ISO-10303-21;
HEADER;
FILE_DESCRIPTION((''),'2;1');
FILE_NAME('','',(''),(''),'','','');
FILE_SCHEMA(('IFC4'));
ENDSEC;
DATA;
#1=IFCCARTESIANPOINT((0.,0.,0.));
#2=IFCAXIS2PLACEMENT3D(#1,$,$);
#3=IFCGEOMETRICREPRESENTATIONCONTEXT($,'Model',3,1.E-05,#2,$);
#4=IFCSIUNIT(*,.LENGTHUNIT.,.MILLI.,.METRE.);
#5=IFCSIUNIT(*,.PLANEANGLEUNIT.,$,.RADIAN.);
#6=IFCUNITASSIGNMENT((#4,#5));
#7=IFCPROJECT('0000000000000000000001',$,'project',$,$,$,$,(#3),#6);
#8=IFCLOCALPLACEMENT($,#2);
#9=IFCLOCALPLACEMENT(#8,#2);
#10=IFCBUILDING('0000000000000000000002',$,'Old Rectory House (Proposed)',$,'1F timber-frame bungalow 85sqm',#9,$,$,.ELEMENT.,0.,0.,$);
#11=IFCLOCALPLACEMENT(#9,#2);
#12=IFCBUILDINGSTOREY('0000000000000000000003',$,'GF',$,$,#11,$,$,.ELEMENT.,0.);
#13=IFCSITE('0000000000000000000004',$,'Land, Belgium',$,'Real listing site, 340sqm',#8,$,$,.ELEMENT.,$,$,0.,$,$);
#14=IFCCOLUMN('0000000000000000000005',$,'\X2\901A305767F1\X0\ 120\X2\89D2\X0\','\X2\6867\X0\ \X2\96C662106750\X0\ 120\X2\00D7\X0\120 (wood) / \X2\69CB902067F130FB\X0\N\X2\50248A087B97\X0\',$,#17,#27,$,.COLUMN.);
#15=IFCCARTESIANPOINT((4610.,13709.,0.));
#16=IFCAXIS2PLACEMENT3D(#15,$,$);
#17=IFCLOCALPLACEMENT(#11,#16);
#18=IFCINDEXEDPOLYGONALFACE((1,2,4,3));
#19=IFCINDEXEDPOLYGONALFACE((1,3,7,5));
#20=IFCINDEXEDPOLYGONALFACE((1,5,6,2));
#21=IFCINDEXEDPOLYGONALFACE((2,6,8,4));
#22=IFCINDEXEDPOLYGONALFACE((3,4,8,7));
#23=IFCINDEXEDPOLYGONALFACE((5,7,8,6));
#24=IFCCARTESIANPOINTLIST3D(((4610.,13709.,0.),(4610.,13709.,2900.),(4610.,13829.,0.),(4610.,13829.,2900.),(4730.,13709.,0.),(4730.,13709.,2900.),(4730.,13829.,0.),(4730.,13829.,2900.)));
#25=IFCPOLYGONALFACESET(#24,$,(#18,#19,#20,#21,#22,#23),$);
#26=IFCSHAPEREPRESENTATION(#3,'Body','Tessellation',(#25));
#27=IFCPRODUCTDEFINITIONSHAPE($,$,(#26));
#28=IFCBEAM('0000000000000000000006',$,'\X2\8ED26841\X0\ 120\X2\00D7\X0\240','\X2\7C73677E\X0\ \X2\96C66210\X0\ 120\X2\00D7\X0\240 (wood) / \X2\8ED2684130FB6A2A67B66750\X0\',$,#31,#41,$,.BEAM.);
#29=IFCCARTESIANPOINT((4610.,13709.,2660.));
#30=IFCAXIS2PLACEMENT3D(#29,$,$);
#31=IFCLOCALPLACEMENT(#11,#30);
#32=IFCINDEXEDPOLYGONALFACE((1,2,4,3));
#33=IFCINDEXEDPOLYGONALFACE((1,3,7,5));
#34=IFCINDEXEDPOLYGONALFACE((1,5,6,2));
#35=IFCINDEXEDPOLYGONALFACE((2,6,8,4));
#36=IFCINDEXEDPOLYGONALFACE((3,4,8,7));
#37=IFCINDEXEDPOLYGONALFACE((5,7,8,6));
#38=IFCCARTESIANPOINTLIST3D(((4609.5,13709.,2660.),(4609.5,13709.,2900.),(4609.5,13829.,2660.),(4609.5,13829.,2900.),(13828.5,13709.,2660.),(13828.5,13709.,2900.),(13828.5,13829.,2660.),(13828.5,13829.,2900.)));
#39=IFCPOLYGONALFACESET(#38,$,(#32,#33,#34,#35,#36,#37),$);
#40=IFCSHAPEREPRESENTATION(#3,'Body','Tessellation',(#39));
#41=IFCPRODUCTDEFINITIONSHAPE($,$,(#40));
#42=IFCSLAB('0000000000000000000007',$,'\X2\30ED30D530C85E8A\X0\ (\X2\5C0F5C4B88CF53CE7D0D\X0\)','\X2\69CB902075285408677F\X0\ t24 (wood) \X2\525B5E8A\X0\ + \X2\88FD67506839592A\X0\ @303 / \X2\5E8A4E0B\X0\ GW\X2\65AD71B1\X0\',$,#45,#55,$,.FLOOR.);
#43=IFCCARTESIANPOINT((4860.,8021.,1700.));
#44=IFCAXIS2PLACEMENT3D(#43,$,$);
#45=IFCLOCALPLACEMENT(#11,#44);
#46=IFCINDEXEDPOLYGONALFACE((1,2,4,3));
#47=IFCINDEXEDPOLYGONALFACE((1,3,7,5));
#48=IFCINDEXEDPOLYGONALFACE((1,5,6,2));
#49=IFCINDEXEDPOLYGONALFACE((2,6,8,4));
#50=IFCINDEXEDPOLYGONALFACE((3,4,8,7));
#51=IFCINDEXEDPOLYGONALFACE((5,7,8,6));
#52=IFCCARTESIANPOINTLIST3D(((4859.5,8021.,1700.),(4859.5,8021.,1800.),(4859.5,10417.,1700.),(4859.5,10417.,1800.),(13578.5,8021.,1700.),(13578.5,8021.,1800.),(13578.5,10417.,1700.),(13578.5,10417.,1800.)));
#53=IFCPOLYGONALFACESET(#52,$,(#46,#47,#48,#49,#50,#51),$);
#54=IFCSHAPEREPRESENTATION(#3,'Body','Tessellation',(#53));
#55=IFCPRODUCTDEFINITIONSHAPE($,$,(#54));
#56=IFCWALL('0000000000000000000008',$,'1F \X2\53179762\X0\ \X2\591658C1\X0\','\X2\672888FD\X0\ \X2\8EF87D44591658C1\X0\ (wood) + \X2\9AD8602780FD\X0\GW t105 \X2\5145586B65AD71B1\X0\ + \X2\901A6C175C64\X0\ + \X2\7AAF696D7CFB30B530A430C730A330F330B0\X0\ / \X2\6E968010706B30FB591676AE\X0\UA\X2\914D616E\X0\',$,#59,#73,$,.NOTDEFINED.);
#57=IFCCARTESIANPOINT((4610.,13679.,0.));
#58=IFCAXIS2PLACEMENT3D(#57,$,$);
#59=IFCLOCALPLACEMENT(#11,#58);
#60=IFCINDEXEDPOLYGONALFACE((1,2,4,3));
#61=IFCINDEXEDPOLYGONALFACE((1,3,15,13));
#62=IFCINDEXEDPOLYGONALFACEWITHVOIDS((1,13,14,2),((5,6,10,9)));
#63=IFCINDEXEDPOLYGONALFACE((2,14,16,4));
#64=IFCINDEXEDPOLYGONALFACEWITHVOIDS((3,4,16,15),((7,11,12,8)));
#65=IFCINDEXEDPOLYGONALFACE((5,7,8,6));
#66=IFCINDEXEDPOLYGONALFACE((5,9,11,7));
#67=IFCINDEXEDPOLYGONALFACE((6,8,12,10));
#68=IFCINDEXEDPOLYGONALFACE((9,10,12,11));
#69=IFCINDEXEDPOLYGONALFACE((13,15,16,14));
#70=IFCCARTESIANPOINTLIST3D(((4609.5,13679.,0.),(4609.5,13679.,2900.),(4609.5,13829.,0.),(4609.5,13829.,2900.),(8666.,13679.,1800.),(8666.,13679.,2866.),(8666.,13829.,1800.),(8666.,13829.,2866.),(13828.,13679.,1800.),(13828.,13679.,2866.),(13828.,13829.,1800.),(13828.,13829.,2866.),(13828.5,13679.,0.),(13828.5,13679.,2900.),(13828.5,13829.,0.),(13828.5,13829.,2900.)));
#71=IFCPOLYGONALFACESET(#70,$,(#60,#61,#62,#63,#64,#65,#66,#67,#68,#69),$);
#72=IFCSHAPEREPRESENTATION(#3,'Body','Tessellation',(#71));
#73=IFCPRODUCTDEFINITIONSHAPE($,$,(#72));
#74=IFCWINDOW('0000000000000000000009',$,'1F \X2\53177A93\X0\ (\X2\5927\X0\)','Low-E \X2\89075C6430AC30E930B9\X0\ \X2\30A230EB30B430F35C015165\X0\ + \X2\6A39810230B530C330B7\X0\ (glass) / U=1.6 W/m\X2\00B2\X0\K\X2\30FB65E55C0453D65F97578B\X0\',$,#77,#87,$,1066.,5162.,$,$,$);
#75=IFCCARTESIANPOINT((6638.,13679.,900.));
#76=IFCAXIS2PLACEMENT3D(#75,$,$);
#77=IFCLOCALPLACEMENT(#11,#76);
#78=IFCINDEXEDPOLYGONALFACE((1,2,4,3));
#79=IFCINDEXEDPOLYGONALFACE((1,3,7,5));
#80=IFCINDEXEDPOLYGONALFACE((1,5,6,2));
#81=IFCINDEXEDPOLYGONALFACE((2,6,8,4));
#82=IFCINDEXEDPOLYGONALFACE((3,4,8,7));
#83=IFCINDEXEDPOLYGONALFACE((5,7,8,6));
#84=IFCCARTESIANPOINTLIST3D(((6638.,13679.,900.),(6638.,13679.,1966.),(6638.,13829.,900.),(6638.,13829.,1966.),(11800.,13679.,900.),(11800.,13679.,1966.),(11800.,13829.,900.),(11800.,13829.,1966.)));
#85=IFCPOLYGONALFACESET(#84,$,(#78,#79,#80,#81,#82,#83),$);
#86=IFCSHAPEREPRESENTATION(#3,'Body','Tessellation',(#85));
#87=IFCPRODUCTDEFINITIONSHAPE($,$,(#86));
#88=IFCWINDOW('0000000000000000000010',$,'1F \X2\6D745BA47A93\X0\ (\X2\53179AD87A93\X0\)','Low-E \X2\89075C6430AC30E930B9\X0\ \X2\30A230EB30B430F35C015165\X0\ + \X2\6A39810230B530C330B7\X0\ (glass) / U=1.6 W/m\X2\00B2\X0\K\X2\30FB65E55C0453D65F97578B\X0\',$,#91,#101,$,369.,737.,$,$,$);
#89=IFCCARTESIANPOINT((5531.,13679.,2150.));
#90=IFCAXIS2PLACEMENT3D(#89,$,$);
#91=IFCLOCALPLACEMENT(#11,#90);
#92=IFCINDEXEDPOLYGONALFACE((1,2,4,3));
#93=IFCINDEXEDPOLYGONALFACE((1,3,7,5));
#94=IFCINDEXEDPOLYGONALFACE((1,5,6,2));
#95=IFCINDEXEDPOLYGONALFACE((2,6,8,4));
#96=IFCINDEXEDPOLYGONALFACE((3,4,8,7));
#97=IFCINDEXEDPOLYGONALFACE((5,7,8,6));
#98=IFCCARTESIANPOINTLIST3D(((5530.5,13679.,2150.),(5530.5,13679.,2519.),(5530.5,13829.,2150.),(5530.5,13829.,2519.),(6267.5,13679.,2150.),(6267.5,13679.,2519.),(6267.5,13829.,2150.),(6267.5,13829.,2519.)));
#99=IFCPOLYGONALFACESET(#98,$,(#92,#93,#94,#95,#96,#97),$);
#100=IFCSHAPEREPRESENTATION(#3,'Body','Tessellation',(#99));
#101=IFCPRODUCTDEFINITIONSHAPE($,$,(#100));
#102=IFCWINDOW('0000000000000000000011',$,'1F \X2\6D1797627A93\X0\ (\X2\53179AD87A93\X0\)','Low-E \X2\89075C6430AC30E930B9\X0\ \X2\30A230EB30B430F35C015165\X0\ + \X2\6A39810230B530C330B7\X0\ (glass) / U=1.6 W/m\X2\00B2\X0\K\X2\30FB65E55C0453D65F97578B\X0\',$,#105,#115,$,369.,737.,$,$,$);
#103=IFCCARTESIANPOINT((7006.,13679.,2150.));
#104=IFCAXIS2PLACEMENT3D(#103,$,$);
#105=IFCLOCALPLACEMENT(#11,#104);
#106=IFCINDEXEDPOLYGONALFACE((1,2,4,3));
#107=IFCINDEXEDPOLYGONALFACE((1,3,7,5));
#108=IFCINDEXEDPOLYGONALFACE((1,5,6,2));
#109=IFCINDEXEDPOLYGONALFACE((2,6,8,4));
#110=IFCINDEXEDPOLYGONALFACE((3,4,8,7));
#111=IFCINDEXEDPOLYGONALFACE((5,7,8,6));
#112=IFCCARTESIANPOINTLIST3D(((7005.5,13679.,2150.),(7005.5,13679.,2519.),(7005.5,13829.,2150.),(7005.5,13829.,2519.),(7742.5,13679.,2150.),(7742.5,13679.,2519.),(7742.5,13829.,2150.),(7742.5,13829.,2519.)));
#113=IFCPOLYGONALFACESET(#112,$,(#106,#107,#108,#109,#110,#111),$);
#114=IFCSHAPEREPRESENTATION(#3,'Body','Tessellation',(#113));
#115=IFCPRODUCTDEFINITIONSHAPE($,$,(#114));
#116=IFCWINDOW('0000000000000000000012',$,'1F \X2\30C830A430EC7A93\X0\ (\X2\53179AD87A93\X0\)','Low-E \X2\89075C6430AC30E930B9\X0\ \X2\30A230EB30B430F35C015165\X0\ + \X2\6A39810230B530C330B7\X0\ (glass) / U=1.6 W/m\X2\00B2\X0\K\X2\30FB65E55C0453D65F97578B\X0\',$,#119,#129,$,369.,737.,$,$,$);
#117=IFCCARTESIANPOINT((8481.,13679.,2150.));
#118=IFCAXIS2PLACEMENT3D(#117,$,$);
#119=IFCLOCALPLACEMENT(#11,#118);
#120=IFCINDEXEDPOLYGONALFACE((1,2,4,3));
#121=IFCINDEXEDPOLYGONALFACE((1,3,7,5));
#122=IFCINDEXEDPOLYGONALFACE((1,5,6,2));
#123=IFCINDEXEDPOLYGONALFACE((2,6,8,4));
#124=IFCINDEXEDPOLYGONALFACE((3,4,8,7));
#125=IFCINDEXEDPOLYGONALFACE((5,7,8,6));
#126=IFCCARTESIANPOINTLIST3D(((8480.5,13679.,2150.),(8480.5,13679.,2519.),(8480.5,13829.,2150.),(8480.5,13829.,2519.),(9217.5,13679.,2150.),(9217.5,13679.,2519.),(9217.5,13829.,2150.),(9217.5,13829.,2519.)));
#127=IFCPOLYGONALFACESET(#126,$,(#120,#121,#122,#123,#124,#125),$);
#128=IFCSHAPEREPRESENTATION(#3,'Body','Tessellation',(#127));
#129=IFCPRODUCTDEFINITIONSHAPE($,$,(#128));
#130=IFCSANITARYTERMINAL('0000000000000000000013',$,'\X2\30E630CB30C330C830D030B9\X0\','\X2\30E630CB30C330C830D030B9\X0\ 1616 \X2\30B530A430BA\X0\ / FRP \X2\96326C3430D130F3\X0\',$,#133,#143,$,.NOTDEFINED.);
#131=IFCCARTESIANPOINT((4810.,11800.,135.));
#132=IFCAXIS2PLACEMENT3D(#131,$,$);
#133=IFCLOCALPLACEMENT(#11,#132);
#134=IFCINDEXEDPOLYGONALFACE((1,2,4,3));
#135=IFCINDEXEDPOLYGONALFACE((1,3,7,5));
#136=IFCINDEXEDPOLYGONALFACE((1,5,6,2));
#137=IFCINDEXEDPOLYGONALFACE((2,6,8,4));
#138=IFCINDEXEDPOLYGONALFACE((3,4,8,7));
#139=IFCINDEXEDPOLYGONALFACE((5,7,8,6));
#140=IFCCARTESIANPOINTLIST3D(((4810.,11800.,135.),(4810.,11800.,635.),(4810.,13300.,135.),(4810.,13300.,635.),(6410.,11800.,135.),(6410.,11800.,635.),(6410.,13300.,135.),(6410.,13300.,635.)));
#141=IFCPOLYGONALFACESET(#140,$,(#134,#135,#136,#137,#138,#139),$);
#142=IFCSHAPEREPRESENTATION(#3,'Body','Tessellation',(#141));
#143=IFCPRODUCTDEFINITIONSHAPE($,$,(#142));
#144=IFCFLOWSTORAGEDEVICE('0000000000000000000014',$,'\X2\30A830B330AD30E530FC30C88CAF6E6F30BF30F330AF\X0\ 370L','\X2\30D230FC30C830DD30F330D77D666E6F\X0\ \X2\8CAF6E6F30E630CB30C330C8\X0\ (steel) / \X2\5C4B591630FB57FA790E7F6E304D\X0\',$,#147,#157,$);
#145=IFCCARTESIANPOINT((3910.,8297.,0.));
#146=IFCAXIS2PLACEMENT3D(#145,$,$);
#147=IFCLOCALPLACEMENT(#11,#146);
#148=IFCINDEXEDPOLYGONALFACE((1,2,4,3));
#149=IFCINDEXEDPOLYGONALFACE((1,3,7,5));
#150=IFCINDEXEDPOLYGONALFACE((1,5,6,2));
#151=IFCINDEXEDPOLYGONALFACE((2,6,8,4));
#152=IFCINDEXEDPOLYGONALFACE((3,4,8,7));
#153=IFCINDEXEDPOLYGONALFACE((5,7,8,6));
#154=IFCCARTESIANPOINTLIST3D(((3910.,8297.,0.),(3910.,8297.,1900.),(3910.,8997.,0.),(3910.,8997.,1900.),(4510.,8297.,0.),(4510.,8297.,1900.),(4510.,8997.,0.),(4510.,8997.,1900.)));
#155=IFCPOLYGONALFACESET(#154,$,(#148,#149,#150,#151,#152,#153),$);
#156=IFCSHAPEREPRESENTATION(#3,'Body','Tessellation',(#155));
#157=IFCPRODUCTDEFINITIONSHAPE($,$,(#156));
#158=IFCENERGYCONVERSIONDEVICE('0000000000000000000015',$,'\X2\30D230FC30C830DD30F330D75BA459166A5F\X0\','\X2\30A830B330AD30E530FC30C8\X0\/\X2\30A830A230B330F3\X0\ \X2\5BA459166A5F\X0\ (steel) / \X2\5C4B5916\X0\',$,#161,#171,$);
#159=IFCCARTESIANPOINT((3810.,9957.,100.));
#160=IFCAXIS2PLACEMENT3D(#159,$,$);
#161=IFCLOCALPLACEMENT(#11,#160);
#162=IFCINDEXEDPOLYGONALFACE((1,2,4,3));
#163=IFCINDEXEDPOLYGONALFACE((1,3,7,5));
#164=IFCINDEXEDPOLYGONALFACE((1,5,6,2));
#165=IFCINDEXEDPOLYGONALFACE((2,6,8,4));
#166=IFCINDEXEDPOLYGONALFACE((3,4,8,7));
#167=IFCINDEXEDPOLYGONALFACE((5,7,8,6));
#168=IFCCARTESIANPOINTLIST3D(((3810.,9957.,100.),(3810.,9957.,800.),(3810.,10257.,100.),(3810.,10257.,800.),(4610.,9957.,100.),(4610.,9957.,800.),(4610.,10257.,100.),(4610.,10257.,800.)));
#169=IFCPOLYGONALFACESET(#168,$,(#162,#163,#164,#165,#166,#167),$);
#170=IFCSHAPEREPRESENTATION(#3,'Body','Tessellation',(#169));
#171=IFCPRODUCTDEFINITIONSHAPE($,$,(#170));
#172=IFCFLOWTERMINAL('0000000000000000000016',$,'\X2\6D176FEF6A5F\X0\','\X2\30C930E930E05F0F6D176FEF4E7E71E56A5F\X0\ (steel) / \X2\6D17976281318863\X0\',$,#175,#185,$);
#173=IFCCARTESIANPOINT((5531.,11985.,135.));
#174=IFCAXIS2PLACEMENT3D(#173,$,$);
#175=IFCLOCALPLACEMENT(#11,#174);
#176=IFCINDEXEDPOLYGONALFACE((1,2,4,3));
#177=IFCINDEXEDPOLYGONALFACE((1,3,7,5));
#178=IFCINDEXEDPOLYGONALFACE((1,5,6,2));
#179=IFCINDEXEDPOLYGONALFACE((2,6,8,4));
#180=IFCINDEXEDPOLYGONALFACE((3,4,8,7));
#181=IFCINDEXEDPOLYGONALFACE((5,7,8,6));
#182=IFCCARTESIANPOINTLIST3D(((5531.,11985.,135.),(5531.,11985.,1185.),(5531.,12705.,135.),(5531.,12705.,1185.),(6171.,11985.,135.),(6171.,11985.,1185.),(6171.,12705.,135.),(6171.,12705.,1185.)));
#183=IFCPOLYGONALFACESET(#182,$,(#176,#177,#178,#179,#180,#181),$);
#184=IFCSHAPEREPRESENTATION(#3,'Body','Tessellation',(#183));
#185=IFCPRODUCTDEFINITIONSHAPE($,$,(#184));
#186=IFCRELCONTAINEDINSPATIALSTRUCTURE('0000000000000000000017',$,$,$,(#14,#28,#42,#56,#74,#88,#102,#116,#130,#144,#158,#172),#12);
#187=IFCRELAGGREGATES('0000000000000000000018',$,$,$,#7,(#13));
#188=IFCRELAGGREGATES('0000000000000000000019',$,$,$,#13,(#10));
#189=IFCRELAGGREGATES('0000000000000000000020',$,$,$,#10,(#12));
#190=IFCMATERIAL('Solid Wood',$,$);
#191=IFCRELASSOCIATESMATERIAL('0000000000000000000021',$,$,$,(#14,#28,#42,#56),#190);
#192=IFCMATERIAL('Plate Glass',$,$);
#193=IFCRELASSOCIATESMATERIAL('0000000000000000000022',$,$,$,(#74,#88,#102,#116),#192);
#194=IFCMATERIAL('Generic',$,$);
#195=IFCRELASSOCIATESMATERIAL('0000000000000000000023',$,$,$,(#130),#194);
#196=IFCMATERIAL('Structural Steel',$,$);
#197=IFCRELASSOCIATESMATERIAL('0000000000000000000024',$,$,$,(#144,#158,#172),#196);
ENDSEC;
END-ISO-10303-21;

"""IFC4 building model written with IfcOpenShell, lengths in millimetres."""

from ifc_helpers import new_model, si_unit, frame, frame_2d, origin, place, context, project, spatial, rectangle, extrude, material, element, fill, save


model = new_model("IFC4")

# Units and contexts
model_context = context("Model", 3, precision=1e-05, world=origin())
ifc_project = project(units=[si_unit("LENGTHUNIT", "METRE", prefix="MILLI"), si_unit("PLANEANGLEUNIT", "RADIAN")], contexts=[model_context])

# Site, building, storey
site_placement = place(None, origin())
site = spatial("IfcSite", under=ifc_project, at=site_placement, Name="Land, Belgium", ObjectType="Real listing site, 340sqm", CompositionType="ELEMENT", RefElevation=0.0)
building_placement = place(site_placement, origin())
building = spatial("IfcBuilding", under=site, at=building_placement, Name="Old Rectory House (Proposed)", ObjectType="1F timber-frame bungalow 85sqm", CompositionType="ELEMENT", ElevationOfRefHeight=0.0, ElevationOfTerrain=0.0)
storey_placement = place(building_placement, origin())
storey = spatial("IfcBuildingStorey", under=building, at=storey_placement, Name="GF", CompositionType="ELEMENT", Elevation=0.0)

# Column
ifc_material_1 = material(Name="Solid Wood")
column_1_placement = place(storey_placement, frame((4610.0, 13709.0, 0.0)))
element("IfcColumn", 1, at=column_1_placement, inside=storey, material=ifc_material_1, Name="通し柱 120角", Description="桧 集成材 120×120 (wood) / 構造柱・N値計算", PredefinedType="COLUMN", context=model_context, shape_type="SweptSolid", body=[
    extrude(rectangle(XDim=120.0, YDim=120.0, at=frame_2d((60.0, 60.0))), frame((4610.0, 13709.0, 0.0)), (0.0, 0.0, 1.0), 2900.0),
])

# Beam
beam_1_placement = place(storey_placement, frame((4610.0, 13709.0, 2660.0)))
element("IfcBeam", 2, at=beam_1_placement, inside=storey, material=ifc_material_1, Name="軒桁 120×240", Description="米松 集成 120×240 (wood) / 軒桁・横架材", PredefinedType="BEAM", context=model_context, shape_type="SweptSolid", body=[
    extrude(rectangle(XDim=9219.0, YDim=120.0, at=frame_2d((4609.0, 60.0))), frame((4610.0, 13709.0, 2660.0)), (0.0, 0.0, 1.0), 240.0),
])

# Slab
slab_placement = place(storey_placement, frame((4860.0, 8021.0, 1700.0)))
element("IfcSlab", 3, at=slab_placement, inside=storey, material=ifc_material_1, Name="ロフト床 (小屋裏収納)", Description="構造用合板 t24 (wood) 剛床 + 製材根太 @303 / 床下 GW断熱", PredefinedType="FLOOR", context=model_context, shape_type="SweptSolid", body=[
    extrude(rectangle(XDim=8719.0, YDim=2396.0, at=frame_2d((4359.0, 1198.0))), frame((4860.0, 8021.0, 1700.0)), (0.0, 0.0, 1.0), 100.0),
])

# Wall, openings, windows
wall_1_placement = place(storey_placement, frame((4610.0, 13679.0, 0.0)))
wall_1 = element("IfcWall", 4, at=wall_1_placement, inside=storey, material=ifc_material_1, Name="1F 北面 外壁", Description="木製 軸組外壁 (wood) + 高性能GW t105 充填断熱 + 通気層 + 窯業系サイディング / 準耐火・外皮UA配慮", PredefinedType="NOTDEFINED", context=model_context, shape_type="SweptSolid", body=[
    extrude(rectangle(XDim=9219.0, YDim=150.0, at=frame_2d((4609.0, 75.0))), frame((4610.0, 13679.0, 0.0)), (0.0, 0.0, 1.0), 2900.0),
])
opening_1_placement = place(storey_placement, frame((6638.0, 13679.0, 900.0)))
opening_1 = element("IfcOpeningElement", 5, at=opening_1_placement, cuts=wall_1, PredefinedType="NOTDEFINED", context=model_context, shape_type="SweptSolid", body=[
    extrude(rectangle(XDim=5162.0, YDim=150.0, at=frame_2d((2581.0, 75.0))), frame((6638.0, 13679.0, 900.0)), (0.0, 0.0, 1.0), 1066.0),
])
opening_2_placement = place(storey_placement, frame((5531.0, 13679.0, 2150.0)))
opening_2 = element("IfcOpeningElement", 6, at=opening_2_placement, cuts=wall_1, PredefinedType="NOTDEFINED", context=model_context, shape_type="SweptSolid", body=[
    extrude(rectangle(XDim=737.0, YDim=150.0, at=frame_2d((368.0, 75.0))), frame((5531.0, 13679.0, 2150.0)), (0.0, 0.0, 1.0), 369.0),
])
opening_3_placement = place(storey_placement, frame((7006.0, 13679.0, 2150.0)))
opening_3 = element("IfcOpeningElement", 7, at=opening_3_placement, cuts=wall_1, PredefinedType="NOTDEFINED", context=model_context, shape_type="SweptSolid", body=[
    extrude(rectangle(XDim=737.0, YDim=150.0, at=frame_2d((368.0, 75.0))), frame((7006.0, 13679.0, 2150.0)), (0.0, 0.0, 1.0), 369.0),
])
opening_4_placement = place(storey_placement, frame((8481.0, 13679.0, 2150.0)))
opening_4 = element("IfcOpeningElement", 8, at=opening_4_placement, cuts=wall_1, PredefinedType="NOTDEFINED", context=model_context, shape_type="SweptSolid", body=[
    extrude(rectangle(XDim=737.0, YDim=150.0, at=frame_2d((368.0, 75.0))), frame((8481.0, 13679.0, 2150.0)), (0.0, 0.0, 1.0), 369.0),
])
ifc_material_2 = material(Name="Plate Glass")
window_1_placement = place(storey_placement, frame((6638.0, 13679.0, 900.0)))
window_1 = element("IfcWindow", 9, at=window_1_placement, inside=storey, material=ifc_material_2, Name="1F 北窓 (大)", Description="Low-E 複層ガラス アルゴン封入 + 樹脂サッシ (glass) / U=1.6 W/m²K・日射取得型", OverallHeight=1066.0, OverallWidth=5162.0, context=model_context, shape_type="SweptSolid", body=[
    extrude(rectangle(XDim=5162.0, YDim=150.0, at=frame_2d((2581.0, 75.0))), frame((6638.0, 13679.0, 900.0)), (0.0, 0.0, 1.0), 1066.0),
])
fill(opening_1, window_1)
window_2_placement = place(storey_placement, frame((5531.0, 13679.0, 2150.0)))
window_2 = element("IfcWindow", 10, at=window_2_placement, inside=storey, material=ifc_material_2, Name="1F 浴室窓 (北高窓)", Description="Low-E 複層ガラス アルゴン封入 + 樹脂サッシ (glass) / U=1.6 W/m²K・日射取得型", OverallHeight=369.0, OverallWidth=737.0, context=model_context, shape_type="SweptSolid", body=[
    extrude(rectangle(XDim=737.0, YDim=150.0, at=frame_2d((368.0, 75.0))), frame((5531.0, 13679.0, 2150.0)), (0.0, 0.0, 1.0), 369.0),
])
fill(opening_2, window_2)
window_3_placement = place(storey_placement, frame((7006.0, 13679.0, 2150.0)))
window_3 = element("IfcWindow", 11, at=window_3_placement, inside=storey, material=ifc_material_2, Name="1F 洗面窓 (北高窓)", Description="Low-E 複層ガラス アルゴン封入 + 樹脂サッシ (glass) / U=1.6 W/m²K・日射取得型", OverallHeight=369.0, OverallWidth=737.0, context=model_context, shape_type="SweptSolid", body=[
    extrude(rectangle(XDim=737.0, YDim=150.0, at=frame_2d((368.0, 75.0))), frame((7006.0, 13679.0, 2150.0)), (0.0, 0.0, 1.0), 369.0),
])
fill(opening_3, window_3)
window_4_placement = place(storey_placement, frame((8481.0, 13679.0, 2150.0)))
window_4 = element("IfcWindow", 12, at=window_4_placement, inside=storey, material=ifc_material_2, Name="1F トイレ窓 (北高窓)", Description="Low-E 複層ガラス アルゴン封入 + 樹脂サッシ (glass) / U=1.6 W/m²K・日射取得型", OverallHeight=369.0, OverallWidth=737.0, context=model_context, shape_type="SweptSolid", body=[
    extrude(rectangle(XDim=737.0, YDim=150.0, at=frame_2d((368.0, 75.0))), frame((8481.0, 13679.0, 2150.0)), (0.0, 0.0, 1.0), 369.0),
])
fill(opening_4, window_4)

# Shared definitions
ifc_material_3 = material(Name="Structural Steel")

# Sanitary terminal
ifc_material_4 = material(Name="Generic")
sanitary_terminal_placement = place(storey_placement, frame((4810.0, 11800.0, 135.0)))
element("IfcSanitaryTerminal", 13, at=sanitary_terminal_placement, inside=storey, material=ifc_material_4, Name="ユニットバス", Description="ユニットバス 1616 サイズ / FRP 防水パン", PredefinedType="NOTDEFINED", context=model_context, shape_type="SweptSolid", body=[
    extrude(rectangle(XDim=1600.0, YDim=1500.0, at=frame_2d((800.0, 750.0))), frame((4810.0, 11800.0, 135.0)), (0.0, 0.0, 1.0), 500.0),
])

# Flow storage device
flow_storage_device_placement = place(storey_placement, frame((3910.0, 8297.0, 0.0)))
element("IfcFlowStorageDevice", 14, at=flow_storage_device_placement, inside=storey, material=ifc_material_3, Name="エコキュート貯湯タンク 370L", Description="ヒートポンプ給湯 貯湯ユニット (steel) / 屋外・基礎置き", context=model_context, shape_type="SweptSolid", body=[
    extrude(rectangle(XDim=600.0, YDim=700.0, at=frame_2d((300.0, 350.0))), frame((3910.0, 8297.0, 0.0)), (0.0, 0.0, 1.0), 1900.0),
])

# Energy conversion device
energy_conversion_device_placement = place(storey_placement, frame((3810.0, 9957.0, 100.0)))
element("IfcEnergyConversionDevice", 15, at=energy_conversion_device_placement, inside=storey, material=ifc_material_3, Name="ヒートポンプ室外機", Description="エコキュート/エアコン 室外機 (steel) / 屋外", context=model_context, shape_type="SweptSolid", body=[
    extrude(rectangle(XDim=800.0, YDim=300.0, at=frame_2d((400.0, 150.0))), frame((3810.0, 9957.0, 100.0)), (0.0, 0.0, 1.0), 700.0),
])

# Flow terminal
flow_terminal_placement = place(storey_placement, frame((5531.0, 11985.0, 135.0)))
element("IfcFlowTerminal", 16, at=flow_terminal_placement, inside=storey, material=ifc_material_3, Name="洗濯機", Description="ドラム式洗濯乾燥機 (steel) / 洗面脱衣", context=model_context, shape_type="SweptSolid", body=[
    extrude(rectangle(XDim=640.0, YDim=720.0, at=frame_2d((320.0, 360.0))), frame((5531.0, 11985.0, 135.0)), (0.0, 0.0, 1.0), 1050.0),
])

save(model, "model.ifc")
